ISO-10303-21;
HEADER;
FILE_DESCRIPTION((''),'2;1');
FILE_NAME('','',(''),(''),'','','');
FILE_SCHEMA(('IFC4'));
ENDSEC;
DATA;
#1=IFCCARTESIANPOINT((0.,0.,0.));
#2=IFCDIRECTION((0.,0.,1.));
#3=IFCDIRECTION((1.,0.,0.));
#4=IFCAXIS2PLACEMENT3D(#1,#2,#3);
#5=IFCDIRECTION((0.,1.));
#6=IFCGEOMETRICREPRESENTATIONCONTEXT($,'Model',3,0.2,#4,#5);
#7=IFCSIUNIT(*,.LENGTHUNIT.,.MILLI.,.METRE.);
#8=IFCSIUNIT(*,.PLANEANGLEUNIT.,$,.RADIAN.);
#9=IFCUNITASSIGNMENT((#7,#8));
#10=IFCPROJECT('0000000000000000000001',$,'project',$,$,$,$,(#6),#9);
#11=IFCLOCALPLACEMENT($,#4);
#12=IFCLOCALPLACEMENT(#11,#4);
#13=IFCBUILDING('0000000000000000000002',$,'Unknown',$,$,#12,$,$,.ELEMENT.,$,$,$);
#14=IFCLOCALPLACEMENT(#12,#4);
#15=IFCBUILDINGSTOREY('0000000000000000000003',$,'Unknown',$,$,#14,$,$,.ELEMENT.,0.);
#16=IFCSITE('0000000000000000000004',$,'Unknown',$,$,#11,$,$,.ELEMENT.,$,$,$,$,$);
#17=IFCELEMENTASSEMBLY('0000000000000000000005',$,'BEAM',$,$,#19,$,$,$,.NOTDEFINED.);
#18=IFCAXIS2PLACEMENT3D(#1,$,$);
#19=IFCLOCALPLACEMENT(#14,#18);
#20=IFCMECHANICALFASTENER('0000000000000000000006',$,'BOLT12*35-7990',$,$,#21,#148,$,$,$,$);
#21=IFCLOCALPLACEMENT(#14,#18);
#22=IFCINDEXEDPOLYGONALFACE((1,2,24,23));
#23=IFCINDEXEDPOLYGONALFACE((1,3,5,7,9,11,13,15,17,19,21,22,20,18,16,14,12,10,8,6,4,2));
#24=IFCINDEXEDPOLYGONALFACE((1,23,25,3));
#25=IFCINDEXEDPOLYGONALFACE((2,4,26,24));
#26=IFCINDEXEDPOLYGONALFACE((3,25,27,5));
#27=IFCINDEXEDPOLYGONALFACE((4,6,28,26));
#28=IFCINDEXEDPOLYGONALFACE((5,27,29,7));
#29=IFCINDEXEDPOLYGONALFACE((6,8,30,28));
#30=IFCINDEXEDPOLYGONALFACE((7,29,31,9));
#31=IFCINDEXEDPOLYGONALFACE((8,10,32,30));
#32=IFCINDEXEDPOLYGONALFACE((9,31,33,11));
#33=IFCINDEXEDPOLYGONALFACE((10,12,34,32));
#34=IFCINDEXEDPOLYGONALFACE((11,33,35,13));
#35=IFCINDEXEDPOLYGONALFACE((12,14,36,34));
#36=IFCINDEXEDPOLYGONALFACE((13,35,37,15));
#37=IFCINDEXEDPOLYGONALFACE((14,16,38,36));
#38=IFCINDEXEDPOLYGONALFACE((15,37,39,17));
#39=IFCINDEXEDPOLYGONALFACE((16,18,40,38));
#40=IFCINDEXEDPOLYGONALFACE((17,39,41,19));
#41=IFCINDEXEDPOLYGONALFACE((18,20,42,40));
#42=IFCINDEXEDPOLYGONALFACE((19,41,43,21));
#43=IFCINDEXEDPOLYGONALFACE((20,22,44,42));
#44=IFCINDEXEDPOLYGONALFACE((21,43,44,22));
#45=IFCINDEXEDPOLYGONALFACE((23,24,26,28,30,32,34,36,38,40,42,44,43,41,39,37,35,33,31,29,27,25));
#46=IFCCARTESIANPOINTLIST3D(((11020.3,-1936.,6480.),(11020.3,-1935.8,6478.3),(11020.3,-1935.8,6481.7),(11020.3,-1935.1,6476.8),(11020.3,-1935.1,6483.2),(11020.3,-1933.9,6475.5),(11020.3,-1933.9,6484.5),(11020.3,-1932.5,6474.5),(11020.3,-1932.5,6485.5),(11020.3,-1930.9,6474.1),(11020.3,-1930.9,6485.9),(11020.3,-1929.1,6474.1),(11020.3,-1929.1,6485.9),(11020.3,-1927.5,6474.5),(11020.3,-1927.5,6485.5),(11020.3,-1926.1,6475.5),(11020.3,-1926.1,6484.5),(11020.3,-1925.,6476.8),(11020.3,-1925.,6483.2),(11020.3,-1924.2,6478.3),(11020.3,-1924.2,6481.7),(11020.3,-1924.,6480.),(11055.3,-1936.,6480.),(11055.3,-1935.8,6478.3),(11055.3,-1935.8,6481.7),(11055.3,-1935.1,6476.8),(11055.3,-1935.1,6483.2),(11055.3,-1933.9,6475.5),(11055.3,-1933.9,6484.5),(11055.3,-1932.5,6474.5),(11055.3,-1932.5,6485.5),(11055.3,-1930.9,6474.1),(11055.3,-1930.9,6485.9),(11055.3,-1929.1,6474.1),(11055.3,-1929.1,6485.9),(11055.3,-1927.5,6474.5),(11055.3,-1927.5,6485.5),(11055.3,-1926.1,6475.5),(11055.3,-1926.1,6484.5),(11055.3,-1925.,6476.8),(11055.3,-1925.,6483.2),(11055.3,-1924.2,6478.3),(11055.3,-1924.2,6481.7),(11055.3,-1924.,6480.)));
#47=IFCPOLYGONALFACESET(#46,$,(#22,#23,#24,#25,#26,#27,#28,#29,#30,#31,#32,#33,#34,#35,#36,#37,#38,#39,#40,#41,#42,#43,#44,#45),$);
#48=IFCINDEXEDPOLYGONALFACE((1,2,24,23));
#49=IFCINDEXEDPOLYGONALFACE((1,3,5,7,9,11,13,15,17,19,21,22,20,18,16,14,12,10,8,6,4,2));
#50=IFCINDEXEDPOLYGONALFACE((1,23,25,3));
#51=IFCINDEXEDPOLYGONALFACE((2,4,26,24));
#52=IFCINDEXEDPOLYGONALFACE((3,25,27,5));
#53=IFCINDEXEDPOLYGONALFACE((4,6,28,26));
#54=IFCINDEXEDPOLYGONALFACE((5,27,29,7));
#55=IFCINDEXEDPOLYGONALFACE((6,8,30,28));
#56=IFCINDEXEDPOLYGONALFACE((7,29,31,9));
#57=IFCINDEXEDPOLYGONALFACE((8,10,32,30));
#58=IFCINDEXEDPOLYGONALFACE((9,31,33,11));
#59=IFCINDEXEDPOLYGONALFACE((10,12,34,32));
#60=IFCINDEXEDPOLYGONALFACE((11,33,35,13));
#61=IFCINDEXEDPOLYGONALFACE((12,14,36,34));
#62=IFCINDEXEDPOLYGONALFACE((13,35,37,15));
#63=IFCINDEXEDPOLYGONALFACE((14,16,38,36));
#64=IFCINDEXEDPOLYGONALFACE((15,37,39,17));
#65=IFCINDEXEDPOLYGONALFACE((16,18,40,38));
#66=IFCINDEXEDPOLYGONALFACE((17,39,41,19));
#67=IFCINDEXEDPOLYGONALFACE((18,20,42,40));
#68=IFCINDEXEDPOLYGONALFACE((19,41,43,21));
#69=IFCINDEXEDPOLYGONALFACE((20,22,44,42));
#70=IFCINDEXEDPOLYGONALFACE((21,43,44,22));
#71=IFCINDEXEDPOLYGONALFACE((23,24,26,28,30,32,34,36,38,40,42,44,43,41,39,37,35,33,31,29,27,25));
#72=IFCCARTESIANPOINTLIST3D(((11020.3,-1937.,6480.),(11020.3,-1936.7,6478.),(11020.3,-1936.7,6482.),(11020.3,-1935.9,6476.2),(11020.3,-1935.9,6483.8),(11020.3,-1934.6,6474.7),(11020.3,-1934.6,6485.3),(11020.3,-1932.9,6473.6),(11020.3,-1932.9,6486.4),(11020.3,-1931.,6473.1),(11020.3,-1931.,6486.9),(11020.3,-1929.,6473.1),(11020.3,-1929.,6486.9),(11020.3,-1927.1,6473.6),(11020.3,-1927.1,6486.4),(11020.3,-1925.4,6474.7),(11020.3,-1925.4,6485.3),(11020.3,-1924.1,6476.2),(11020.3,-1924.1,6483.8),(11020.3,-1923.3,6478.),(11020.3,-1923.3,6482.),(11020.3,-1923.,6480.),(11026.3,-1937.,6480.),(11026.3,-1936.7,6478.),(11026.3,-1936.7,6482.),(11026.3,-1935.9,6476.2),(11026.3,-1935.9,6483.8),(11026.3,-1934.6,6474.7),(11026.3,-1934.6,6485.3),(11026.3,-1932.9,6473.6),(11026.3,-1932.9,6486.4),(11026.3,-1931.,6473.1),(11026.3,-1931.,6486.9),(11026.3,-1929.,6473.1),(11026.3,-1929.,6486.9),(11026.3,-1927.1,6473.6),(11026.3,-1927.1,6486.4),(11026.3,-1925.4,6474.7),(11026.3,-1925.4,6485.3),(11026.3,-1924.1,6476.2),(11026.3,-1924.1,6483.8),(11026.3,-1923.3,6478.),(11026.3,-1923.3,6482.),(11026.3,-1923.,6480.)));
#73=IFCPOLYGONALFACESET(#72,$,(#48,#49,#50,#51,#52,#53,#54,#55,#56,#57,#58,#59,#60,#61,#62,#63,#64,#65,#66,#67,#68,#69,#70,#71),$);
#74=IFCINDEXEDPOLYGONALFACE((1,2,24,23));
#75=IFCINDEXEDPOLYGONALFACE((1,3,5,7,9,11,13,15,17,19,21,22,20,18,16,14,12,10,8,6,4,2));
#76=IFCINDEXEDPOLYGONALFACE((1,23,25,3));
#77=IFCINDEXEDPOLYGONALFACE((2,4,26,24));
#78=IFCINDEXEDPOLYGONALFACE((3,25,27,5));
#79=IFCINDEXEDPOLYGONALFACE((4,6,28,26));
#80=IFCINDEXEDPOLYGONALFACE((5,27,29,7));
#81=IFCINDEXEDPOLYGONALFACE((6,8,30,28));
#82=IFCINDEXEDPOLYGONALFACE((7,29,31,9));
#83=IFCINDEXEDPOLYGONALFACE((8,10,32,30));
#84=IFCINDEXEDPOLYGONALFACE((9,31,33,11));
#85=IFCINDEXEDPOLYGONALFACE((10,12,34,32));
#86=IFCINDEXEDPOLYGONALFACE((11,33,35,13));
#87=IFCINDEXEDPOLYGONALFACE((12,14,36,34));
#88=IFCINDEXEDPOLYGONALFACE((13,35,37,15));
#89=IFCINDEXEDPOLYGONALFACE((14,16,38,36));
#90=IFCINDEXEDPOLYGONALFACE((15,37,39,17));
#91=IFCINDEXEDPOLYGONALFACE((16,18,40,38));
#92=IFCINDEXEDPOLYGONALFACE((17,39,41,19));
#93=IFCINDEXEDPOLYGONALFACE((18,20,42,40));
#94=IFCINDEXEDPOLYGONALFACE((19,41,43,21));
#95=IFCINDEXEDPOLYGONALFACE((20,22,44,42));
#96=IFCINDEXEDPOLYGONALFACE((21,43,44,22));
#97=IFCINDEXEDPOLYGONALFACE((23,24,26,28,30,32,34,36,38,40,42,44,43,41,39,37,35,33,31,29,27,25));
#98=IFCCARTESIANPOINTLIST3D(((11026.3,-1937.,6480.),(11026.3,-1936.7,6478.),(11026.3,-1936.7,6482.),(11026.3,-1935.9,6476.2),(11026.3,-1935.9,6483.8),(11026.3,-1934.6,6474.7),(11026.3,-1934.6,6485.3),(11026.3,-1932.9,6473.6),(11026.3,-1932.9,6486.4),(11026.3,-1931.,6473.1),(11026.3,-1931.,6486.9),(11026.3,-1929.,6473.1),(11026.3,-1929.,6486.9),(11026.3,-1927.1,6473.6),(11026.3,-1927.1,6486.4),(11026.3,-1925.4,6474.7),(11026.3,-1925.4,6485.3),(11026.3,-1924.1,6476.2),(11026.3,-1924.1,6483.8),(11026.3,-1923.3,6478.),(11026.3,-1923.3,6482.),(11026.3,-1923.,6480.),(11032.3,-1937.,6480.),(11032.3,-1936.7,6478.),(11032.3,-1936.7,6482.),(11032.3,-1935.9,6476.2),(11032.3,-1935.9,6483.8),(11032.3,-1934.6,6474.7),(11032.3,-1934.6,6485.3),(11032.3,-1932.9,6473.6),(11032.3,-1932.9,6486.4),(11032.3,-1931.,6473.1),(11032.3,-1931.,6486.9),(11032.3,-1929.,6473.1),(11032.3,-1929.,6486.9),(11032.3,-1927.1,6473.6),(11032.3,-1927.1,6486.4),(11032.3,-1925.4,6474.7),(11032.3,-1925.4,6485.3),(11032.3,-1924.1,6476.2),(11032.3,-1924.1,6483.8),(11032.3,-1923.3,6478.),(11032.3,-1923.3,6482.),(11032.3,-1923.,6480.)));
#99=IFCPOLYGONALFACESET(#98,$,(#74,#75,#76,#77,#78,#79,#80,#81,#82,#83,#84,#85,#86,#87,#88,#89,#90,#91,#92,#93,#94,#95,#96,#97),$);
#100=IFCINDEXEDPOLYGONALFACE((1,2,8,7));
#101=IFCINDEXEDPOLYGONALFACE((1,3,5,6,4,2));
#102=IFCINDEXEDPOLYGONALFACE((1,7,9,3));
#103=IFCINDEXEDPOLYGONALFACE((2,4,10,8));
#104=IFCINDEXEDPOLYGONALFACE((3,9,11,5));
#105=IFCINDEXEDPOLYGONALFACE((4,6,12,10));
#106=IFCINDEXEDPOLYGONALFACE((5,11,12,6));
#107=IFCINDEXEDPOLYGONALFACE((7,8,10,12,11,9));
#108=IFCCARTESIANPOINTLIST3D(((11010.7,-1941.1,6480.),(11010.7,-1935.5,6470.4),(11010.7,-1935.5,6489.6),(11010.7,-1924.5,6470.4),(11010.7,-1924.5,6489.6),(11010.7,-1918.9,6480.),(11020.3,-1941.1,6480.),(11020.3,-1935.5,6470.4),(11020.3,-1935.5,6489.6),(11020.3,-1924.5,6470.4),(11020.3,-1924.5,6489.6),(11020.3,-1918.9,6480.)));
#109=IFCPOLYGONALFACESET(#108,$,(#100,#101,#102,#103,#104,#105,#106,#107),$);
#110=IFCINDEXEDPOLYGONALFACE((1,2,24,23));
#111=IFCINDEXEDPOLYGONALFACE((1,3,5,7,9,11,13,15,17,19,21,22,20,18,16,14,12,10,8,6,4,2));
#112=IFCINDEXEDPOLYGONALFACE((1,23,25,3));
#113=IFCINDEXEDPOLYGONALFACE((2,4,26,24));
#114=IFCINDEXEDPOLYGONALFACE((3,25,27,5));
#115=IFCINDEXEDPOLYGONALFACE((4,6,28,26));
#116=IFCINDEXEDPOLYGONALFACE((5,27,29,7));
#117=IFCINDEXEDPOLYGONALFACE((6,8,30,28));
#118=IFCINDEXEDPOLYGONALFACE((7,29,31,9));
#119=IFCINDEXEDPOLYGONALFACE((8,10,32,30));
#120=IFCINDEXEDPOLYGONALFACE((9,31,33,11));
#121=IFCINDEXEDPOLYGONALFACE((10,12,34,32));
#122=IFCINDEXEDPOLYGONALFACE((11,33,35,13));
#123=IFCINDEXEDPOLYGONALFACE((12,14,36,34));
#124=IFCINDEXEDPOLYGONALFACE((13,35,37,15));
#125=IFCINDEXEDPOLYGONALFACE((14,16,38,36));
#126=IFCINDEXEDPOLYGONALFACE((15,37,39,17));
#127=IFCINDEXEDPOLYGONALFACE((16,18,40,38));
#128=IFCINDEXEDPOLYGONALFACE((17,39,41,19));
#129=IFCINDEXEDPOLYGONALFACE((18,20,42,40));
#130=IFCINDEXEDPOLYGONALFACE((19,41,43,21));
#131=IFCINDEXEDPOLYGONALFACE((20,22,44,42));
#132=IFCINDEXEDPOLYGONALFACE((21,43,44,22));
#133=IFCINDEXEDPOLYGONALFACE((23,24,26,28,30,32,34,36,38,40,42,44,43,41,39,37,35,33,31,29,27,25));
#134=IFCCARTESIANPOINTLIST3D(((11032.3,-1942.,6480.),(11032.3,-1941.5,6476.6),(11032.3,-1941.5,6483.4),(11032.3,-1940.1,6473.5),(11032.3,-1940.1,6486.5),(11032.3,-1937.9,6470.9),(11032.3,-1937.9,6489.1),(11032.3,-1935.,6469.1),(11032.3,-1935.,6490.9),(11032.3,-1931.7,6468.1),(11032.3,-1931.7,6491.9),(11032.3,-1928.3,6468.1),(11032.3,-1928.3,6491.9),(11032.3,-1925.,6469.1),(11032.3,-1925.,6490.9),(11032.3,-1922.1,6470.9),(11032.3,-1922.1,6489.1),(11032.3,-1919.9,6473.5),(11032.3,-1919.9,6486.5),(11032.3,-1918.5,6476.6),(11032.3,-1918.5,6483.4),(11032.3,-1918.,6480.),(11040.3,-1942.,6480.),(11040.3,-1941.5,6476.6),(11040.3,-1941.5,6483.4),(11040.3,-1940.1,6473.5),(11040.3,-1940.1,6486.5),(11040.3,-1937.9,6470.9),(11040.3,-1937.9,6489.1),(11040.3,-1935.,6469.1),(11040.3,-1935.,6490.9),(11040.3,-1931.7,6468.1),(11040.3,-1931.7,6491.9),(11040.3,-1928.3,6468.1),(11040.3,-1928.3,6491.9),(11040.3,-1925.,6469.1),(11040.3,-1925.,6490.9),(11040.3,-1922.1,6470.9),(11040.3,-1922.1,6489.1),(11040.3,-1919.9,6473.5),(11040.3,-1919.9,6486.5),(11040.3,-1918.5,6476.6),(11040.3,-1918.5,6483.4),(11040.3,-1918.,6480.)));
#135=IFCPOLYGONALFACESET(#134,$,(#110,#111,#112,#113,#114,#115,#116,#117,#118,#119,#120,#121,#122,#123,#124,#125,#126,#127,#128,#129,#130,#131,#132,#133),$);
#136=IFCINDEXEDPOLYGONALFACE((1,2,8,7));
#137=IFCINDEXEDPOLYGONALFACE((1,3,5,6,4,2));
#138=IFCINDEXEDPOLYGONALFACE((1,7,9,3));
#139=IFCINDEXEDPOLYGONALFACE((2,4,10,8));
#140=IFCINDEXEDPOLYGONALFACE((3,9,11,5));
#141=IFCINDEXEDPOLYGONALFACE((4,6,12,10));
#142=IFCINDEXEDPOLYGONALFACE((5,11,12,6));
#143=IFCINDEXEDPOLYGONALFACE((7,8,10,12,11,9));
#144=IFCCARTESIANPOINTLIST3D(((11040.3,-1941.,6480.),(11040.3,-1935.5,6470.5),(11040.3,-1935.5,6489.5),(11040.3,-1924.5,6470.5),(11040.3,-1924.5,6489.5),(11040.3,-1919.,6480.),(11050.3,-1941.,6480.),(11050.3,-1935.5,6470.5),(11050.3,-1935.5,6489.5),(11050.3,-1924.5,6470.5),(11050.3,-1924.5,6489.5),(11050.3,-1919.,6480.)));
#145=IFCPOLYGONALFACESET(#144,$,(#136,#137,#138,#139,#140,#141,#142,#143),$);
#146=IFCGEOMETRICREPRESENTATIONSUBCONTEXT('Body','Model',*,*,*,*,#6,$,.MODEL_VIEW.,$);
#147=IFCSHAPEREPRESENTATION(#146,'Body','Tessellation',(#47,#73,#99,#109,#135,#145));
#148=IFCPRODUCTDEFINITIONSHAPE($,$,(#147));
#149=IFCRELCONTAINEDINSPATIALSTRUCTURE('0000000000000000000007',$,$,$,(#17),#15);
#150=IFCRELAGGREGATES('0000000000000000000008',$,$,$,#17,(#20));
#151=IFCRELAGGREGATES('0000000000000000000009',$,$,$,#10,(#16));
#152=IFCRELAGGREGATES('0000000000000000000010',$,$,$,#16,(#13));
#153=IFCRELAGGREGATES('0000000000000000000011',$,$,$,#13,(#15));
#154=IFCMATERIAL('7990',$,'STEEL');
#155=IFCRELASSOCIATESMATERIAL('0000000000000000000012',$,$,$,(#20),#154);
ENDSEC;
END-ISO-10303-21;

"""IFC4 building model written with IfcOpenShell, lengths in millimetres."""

from ifc_helpers import new_model, si_unit, direction, frame, origin_with_axes, place, context, subcontext, project, spatial, line, arc, indexed_curve, outline, extrude, source, transform, mapped, material, element, aggregate, save


model = new_model("IFC4")

# Units and contexts
model_context = context("Model", 3, precision=0.2, world=origin_with_axes(), true_north=direction((0.0, 1.0)))
body_context = subcontext(model_context, "Body", "Model", "MODEL_VIEW")
ifc_project = project(units=[si_unit("LENGTHUNIT", "METRE", prefix="MILLI"), si_unit("PLANEANGLEUNIT", "RADIAN")], contexts=[model_context])

# Site, building, storey
site_placement = place(None, origin_with_axes())
site = spatial("IfcSite", under=ifc_project, at=site_placement, Name="Unknown", CompositionType="ELEMENT")
building_placement = place(site_placement, origin_with_axes())
building = spatial("IfcBuilding", under=site, at=building_placement, Name="Unknown", CompositionType="ELEMENT")
storey_placement = place(building_placement, origin_with_axes())
storey = spatial("IfcBuildingStorey", under=building, at=storey_placement, Name="Unknown", CompositionType="ELEMENT", Elevation=0.0)

# Element assembly
assembly_1_placement = place(storey_placement, frame((10996.3, -1930.0, 6450.0), z_axis=(0.0, -1.0, 0.000002), x_axis=(0.0, 0.0, 1.0)))
assembly_1 = element("IfcElementAssembly", 1, at=assembly_1_placement, inside=storey, Name="BEAM", PredefinedType="NOTDEFINED")

# Mechanical fastener
ifc_material_1 = material(Name="7990", Category="STEEL")
shared_shape_1 = source(origin_with_axes(), body_context, "Body", "SweptSolid", [
    extrude(outline(indexed_curve([(6.0, 0.0), (0.0, 6.0), (-6.0, 0.0), (0.0, -6.0)], segments=[arc(1, 2, 3), arc(3, 4, 1)])), frame((0.0, 0.0, 6.0), z_axis=(0.0, -0.000002, -1.0), x_axis=(0.0, 1.0, 0.0)), (0.0, 0.0, 1.0), 35.0),
    extrude(outline(indexed_curve([(7.0, 0.0), (0.0, 7.0), (-7.0, 0.0), (0.0, -7.0)], segments=[arc(1, 2, 3), arc(3, 4, 1)])), frame((0.0, 0.0, 6.0), z_axis=(0.0, -0.000002, -1.0), x_axis=(0.0, 1.0, 0.0)), (0.0, 0.0, 1.0), 6.0),
    extrude(outline(indexed_curve([(7.0, 0.0), (0.0, 7.0), (-7.0, 0.0), (0.0, -7.0)], segments=[arc(1, 2, 3), arc(3, 4, 1)])), frame((0.0, 0.0, 0.0), z_axis=(0.0, -0.000002, -1.0), x_axis=(0.0, 1.0, 0.0)), (0.0, 0.0, 1.0), 6.0),
    extrude(outline(indexed_curve([(11.1, 0.0), (5.5, 9.6), (-5.5, 9.6), (-11.1, 0.0), (-5.5, -9.6), (5.5, -9.6)], segments=[line(1, 2, 3, 4, 5, 6, 1)])), frame((0.0, 0.0, 15.6), z_axis=(0.0, -0.000002, -1.0), x_axis=(0.0, 1.0, 0.0)), (0.0, 0.0, 1.0), 9.6),
    extrude(outline(indexed_curve([(12.0, 0.0), (0.0, 12.0), (-12.0, 0.0), (0.0, -12.0)], segments=[arc(1, 2, 3), arc(3, 4, 1)])), frame((0.0, 0.0, -6.0), z_axis=(0.0, -0.000002, -1.0), x_axis=(0.0, 1.0, 0.0)), (0.0, 0.0, 1.0), 8.0),
    extrude(outline(indexed_curve([(11.0, 0.0), (5.5, 9.5), (-5.5, 9.5), (-11.0, 0.0), (-5.5, -9.5), (5.5, -9.5)], segments=[line(1, 2, 3, 4, 5, 6, 1)])), frame((0.0, 0.0, -14.0), z_axis=(0.0, -0.000002, -1.0), x_axis=(0.0, 1.0, 0.0)), (0.0, 0.0, 1.0), 10.0),
])
mechanical_fastener_1_placement = place(assembly_1_placement, frame((30.0, -30.0, 0.0), z_axis=(0.0, 1.0, 0.0), x_axis=(-1.0, 0.0, 0.0)))
mechanical_fastener_1 = element("IfcMechanicalFastener", 2, at=mechanical_fastener_1_placement, material=ifc_material_1, Name="BOLT12*35-7990", context=body_context, shape_type="MappedRepresentation", body=[
    mapped(shared_shape_1, transform((0.0, 0.0, 0.0))),
])
aggregate(assembly_1, [mechanical_fastener_1])

save(model, "model.ifc")
